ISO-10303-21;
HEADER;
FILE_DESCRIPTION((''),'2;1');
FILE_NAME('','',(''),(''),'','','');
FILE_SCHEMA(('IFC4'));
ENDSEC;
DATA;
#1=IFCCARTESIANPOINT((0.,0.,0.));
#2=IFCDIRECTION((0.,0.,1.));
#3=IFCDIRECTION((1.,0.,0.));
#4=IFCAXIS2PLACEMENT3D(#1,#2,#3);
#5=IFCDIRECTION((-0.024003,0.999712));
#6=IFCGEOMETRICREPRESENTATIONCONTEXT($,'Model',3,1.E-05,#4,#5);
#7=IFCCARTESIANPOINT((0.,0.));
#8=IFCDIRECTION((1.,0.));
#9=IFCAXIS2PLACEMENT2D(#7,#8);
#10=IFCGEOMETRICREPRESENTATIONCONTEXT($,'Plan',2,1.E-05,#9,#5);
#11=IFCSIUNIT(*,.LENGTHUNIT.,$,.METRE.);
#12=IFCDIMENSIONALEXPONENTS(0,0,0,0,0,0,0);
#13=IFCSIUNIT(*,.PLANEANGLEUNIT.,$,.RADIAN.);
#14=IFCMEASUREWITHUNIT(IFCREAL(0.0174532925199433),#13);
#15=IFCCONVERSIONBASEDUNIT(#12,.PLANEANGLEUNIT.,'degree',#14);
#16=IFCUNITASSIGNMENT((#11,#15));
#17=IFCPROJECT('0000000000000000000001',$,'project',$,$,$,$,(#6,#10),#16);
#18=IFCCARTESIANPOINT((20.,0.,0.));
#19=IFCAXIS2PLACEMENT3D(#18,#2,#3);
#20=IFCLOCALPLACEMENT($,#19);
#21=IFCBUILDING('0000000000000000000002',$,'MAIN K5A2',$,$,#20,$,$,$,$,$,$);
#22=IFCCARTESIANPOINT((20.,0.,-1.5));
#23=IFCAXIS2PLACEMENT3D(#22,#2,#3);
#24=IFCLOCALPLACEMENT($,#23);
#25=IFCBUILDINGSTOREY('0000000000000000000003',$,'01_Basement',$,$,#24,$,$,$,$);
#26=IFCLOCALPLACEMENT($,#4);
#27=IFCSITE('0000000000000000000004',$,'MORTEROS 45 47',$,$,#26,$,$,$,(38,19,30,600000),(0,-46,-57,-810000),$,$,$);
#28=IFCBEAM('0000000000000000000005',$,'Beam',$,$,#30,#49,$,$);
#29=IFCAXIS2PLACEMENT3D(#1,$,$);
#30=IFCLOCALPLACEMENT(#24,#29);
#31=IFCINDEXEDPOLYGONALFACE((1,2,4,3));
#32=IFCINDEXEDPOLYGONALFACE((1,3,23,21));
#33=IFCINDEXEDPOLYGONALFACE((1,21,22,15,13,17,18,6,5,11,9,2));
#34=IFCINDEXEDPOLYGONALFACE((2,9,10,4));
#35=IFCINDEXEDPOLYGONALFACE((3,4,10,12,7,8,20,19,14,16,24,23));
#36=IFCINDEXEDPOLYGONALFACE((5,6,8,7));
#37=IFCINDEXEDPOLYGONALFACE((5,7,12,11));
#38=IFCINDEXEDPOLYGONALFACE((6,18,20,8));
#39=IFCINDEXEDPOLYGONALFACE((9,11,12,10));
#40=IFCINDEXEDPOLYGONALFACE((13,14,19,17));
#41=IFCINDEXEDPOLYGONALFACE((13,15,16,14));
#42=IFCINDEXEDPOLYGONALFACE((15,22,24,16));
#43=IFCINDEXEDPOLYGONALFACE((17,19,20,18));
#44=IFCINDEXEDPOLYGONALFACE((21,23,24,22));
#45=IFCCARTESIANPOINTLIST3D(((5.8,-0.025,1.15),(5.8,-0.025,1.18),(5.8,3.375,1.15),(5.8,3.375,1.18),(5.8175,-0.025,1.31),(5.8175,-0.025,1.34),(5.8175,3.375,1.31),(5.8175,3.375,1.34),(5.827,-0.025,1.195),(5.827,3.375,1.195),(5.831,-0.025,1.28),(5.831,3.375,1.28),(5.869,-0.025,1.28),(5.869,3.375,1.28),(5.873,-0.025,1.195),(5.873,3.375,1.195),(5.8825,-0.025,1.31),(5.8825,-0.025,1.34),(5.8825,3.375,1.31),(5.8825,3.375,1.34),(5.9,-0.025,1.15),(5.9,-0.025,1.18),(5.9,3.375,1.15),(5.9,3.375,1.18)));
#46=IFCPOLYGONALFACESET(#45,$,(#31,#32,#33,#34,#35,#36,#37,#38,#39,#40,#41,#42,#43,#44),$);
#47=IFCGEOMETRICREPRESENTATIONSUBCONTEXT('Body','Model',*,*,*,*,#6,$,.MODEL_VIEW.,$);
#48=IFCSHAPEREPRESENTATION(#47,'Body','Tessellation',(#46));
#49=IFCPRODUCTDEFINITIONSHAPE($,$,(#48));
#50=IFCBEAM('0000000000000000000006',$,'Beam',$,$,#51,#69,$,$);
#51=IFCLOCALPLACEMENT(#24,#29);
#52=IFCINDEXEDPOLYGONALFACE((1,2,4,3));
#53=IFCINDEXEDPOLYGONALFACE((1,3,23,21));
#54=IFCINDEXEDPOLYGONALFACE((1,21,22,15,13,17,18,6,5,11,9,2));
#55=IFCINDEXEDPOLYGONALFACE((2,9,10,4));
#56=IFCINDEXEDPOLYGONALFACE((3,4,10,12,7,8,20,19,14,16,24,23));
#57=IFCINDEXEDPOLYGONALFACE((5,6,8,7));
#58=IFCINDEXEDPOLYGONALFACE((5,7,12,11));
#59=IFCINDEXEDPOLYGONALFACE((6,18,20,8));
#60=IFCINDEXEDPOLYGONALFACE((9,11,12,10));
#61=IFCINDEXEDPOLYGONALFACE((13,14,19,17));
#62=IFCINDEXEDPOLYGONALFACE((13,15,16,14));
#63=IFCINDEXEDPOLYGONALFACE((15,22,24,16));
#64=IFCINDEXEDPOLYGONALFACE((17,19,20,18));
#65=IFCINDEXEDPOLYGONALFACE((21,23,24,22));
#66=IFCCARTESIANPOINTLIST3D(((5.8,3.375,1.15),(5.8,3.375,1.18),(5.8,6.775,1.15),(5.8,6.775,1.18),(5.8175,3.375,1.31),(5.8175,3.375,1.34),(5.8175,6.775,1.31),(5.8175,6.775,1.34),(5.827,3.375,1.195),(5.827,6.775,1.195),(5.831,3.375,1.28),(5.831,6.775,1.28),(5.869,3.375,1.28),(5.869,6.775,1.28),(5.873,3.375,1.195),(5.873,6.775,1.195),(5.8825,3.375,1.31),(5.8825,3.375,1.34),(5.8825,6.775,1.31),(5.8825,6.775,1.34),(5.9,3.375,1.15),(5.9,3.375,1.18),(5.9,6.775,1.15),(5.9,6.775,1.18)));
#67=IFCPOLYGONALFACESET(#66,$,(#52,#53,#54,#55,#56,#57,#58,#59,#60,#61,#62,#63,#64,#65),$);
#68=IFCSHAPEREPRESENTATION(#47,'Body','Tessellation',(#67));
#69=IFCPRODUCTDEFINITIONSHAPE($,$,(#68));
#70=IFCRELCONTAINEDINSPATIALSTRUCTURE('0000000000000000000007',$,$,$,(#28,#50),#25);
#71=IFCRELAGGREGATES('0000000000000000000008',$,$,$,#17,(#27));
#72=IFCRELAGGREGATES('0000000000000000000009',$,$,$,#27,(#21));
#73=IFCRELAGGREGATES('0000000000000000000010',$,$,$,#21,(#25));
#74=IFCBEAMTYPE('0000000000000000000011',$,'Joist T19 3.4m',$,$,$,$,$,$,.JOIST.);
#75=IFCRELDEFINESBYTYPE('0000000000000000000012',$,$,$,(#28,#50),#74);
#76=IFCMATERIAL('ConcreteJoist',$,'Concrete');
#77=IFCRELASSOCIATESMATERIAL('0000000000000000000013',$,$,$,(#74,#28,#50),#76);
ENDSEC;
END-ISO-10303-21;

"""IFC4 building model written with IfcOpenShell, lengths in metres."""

from ifc_helpers import new_model, entity, si_unit, converted_unit, direction, frame, origin_with_axes, origin_2d_with_axis, place, context, subcontext, project, spatial, indexed_curve, outline, extrude, material, material_profile, profile_set, profile_usage, type_object, element, save


model = new_model("IFC4")

# Units and contexts
model_context = context("Model", 3, precision=1e-05, world=origin_with_axes(), true_north=direction((-0.024003, 0.999712)))
plan_context = context("Plan", 2, precision=1e-05, world=origin_2d_with_axis(), true_north=direction((-0.024003, 0.999712)))
body_context = subcontext(model_context, "Body", "Model", "MODEL_VIEW")
ifc_project = project(units=[si_unit("LENGTHUNIT", "METRE"), converted_unit("PLANEANGLEUNIT", "degree", entity("IfcReal", 0.0174532925199433), si_unit("PLANEANGLEUNIT", "RADIAN"), dimensions=[0, 0, 0, 0, 0, 0, 0])], contexts=[model_context, plan_context])

# Site, building, storey
site_placement = place(None, origin_with_axes())
site = spatial("IfcSite", under=ifc_project, at=site_placement, Name="MORTEROS 45 47", RefLatitude=(38, 19, 30, 600000), RefLongitude=(0, -46, -57, -810000))
building_placement = place(None, frame((20.0, 0.0, 0.0), z_axis=(0.0, 0.0, 1.0), x_axis=(1.0, 0.0, 0.0)))
building = spatial("IfcBuilding", under=site, at=building_placement, Name="MAIN K5A2")
storey_placement = place(None, frame((20.0, 0.0, -1.5), z_axis=(0.0, 0.0, 1.0), x_axis=(1.0, 0.0, 0.0)))
storey = spatial("IfcBuildingStorey", under=building, at=storey_placement, Name="01_Basement")

# Beams
ifc_material = material(Name="ConcreteJoist", Category="Concrete")
ifc_material_profile = material_profile(ifc_material, outline(indexed_curve([(0.019, 0.13), (0.023, 0.045), (0.05, 0.03), (0.05, 0.0), (-0.05, 0.0), (-0.05, 0.03), (-0.023, 0.045), (-0.019, 0.13), (-0.0325, 0.16), (-0.0325, 0.19), (0.0325, 0.19), (0.0325, 0.16), (0.019, 0.13)])))
ifc_profile_set = profile_set([ifc_material_profile], Name="JoistMaterialProfileSet")
beam_type = type_object("IfcBeamType", Name="Joist T19 3.4m", PredefinedType="JOIST", material=ifc_profile_set)
ifc_profile_usage_1 = profile_usage(ifc_profile_set, cardinal=5)
beam_1_placement = place(None, frame((25.85, -0.025, -0.35), z_axis=(0.0, 1.0, 0.0), x_axis=(-1.0, 0.0, 0.0)))
element("IfcBeam", 1, at=beam_1_placement, inside=storey, type_object=beam_type, material=ifc_profile_usage_1, Name="Beam", context=body_context, shape_type="SweptSolid", body=[
    extrude(outline(indexed_curve([(0.019, 0.13), (0.023, 0.045), (0.05, 0.03), (0.05, 0.0), (-0.05, 0.0), (-0.05, 0.03), (-0.023, 0.045), (-0.019, 0.13), (-0.0325, 0.16), (-0.0325, 0.19), (0.0325, 0.19), (0.0325, 0.16), (0.019, 0.13)])), origin_with_axes(), (0.0, 0.0, 1.0), 3.4),
])
ifc_profile_usage_2 = profile_usage(ifc_profile_set, cardinal=5)
beam_2_placement = place(None, frame((25.85, 3.375, -0.35), z_axis=(0.0, 1.0, 0.0), x_axis=(-1.0, 0.0, 0.0)))
element("IfcBeam", 2, at=beam_2_placement, inside=storey, type_object=beam_type, material=ifc_profile_usage_2, Name="Beam", context=body_context, shape_type="SweptSolid", body=[
    extrude(outline(indexed_curve([(0.019, 0.13), (0.023, 0.045), (0.05, 0.03), (0.05, 0.0), (-0.05, 0.0), (-0.05, 0.03), (-0.023, 0.045), (-0.019, 0.13), (-0.0325, 0.16), (-0.0325, 0.19), (0.0325, 0.19), (0.0325, 0.16), (0.019, 0.13)])), origin_with_axes(), (0.0, 0.0, 1.0), 3.4),
])

save(model, "model.ifc")
